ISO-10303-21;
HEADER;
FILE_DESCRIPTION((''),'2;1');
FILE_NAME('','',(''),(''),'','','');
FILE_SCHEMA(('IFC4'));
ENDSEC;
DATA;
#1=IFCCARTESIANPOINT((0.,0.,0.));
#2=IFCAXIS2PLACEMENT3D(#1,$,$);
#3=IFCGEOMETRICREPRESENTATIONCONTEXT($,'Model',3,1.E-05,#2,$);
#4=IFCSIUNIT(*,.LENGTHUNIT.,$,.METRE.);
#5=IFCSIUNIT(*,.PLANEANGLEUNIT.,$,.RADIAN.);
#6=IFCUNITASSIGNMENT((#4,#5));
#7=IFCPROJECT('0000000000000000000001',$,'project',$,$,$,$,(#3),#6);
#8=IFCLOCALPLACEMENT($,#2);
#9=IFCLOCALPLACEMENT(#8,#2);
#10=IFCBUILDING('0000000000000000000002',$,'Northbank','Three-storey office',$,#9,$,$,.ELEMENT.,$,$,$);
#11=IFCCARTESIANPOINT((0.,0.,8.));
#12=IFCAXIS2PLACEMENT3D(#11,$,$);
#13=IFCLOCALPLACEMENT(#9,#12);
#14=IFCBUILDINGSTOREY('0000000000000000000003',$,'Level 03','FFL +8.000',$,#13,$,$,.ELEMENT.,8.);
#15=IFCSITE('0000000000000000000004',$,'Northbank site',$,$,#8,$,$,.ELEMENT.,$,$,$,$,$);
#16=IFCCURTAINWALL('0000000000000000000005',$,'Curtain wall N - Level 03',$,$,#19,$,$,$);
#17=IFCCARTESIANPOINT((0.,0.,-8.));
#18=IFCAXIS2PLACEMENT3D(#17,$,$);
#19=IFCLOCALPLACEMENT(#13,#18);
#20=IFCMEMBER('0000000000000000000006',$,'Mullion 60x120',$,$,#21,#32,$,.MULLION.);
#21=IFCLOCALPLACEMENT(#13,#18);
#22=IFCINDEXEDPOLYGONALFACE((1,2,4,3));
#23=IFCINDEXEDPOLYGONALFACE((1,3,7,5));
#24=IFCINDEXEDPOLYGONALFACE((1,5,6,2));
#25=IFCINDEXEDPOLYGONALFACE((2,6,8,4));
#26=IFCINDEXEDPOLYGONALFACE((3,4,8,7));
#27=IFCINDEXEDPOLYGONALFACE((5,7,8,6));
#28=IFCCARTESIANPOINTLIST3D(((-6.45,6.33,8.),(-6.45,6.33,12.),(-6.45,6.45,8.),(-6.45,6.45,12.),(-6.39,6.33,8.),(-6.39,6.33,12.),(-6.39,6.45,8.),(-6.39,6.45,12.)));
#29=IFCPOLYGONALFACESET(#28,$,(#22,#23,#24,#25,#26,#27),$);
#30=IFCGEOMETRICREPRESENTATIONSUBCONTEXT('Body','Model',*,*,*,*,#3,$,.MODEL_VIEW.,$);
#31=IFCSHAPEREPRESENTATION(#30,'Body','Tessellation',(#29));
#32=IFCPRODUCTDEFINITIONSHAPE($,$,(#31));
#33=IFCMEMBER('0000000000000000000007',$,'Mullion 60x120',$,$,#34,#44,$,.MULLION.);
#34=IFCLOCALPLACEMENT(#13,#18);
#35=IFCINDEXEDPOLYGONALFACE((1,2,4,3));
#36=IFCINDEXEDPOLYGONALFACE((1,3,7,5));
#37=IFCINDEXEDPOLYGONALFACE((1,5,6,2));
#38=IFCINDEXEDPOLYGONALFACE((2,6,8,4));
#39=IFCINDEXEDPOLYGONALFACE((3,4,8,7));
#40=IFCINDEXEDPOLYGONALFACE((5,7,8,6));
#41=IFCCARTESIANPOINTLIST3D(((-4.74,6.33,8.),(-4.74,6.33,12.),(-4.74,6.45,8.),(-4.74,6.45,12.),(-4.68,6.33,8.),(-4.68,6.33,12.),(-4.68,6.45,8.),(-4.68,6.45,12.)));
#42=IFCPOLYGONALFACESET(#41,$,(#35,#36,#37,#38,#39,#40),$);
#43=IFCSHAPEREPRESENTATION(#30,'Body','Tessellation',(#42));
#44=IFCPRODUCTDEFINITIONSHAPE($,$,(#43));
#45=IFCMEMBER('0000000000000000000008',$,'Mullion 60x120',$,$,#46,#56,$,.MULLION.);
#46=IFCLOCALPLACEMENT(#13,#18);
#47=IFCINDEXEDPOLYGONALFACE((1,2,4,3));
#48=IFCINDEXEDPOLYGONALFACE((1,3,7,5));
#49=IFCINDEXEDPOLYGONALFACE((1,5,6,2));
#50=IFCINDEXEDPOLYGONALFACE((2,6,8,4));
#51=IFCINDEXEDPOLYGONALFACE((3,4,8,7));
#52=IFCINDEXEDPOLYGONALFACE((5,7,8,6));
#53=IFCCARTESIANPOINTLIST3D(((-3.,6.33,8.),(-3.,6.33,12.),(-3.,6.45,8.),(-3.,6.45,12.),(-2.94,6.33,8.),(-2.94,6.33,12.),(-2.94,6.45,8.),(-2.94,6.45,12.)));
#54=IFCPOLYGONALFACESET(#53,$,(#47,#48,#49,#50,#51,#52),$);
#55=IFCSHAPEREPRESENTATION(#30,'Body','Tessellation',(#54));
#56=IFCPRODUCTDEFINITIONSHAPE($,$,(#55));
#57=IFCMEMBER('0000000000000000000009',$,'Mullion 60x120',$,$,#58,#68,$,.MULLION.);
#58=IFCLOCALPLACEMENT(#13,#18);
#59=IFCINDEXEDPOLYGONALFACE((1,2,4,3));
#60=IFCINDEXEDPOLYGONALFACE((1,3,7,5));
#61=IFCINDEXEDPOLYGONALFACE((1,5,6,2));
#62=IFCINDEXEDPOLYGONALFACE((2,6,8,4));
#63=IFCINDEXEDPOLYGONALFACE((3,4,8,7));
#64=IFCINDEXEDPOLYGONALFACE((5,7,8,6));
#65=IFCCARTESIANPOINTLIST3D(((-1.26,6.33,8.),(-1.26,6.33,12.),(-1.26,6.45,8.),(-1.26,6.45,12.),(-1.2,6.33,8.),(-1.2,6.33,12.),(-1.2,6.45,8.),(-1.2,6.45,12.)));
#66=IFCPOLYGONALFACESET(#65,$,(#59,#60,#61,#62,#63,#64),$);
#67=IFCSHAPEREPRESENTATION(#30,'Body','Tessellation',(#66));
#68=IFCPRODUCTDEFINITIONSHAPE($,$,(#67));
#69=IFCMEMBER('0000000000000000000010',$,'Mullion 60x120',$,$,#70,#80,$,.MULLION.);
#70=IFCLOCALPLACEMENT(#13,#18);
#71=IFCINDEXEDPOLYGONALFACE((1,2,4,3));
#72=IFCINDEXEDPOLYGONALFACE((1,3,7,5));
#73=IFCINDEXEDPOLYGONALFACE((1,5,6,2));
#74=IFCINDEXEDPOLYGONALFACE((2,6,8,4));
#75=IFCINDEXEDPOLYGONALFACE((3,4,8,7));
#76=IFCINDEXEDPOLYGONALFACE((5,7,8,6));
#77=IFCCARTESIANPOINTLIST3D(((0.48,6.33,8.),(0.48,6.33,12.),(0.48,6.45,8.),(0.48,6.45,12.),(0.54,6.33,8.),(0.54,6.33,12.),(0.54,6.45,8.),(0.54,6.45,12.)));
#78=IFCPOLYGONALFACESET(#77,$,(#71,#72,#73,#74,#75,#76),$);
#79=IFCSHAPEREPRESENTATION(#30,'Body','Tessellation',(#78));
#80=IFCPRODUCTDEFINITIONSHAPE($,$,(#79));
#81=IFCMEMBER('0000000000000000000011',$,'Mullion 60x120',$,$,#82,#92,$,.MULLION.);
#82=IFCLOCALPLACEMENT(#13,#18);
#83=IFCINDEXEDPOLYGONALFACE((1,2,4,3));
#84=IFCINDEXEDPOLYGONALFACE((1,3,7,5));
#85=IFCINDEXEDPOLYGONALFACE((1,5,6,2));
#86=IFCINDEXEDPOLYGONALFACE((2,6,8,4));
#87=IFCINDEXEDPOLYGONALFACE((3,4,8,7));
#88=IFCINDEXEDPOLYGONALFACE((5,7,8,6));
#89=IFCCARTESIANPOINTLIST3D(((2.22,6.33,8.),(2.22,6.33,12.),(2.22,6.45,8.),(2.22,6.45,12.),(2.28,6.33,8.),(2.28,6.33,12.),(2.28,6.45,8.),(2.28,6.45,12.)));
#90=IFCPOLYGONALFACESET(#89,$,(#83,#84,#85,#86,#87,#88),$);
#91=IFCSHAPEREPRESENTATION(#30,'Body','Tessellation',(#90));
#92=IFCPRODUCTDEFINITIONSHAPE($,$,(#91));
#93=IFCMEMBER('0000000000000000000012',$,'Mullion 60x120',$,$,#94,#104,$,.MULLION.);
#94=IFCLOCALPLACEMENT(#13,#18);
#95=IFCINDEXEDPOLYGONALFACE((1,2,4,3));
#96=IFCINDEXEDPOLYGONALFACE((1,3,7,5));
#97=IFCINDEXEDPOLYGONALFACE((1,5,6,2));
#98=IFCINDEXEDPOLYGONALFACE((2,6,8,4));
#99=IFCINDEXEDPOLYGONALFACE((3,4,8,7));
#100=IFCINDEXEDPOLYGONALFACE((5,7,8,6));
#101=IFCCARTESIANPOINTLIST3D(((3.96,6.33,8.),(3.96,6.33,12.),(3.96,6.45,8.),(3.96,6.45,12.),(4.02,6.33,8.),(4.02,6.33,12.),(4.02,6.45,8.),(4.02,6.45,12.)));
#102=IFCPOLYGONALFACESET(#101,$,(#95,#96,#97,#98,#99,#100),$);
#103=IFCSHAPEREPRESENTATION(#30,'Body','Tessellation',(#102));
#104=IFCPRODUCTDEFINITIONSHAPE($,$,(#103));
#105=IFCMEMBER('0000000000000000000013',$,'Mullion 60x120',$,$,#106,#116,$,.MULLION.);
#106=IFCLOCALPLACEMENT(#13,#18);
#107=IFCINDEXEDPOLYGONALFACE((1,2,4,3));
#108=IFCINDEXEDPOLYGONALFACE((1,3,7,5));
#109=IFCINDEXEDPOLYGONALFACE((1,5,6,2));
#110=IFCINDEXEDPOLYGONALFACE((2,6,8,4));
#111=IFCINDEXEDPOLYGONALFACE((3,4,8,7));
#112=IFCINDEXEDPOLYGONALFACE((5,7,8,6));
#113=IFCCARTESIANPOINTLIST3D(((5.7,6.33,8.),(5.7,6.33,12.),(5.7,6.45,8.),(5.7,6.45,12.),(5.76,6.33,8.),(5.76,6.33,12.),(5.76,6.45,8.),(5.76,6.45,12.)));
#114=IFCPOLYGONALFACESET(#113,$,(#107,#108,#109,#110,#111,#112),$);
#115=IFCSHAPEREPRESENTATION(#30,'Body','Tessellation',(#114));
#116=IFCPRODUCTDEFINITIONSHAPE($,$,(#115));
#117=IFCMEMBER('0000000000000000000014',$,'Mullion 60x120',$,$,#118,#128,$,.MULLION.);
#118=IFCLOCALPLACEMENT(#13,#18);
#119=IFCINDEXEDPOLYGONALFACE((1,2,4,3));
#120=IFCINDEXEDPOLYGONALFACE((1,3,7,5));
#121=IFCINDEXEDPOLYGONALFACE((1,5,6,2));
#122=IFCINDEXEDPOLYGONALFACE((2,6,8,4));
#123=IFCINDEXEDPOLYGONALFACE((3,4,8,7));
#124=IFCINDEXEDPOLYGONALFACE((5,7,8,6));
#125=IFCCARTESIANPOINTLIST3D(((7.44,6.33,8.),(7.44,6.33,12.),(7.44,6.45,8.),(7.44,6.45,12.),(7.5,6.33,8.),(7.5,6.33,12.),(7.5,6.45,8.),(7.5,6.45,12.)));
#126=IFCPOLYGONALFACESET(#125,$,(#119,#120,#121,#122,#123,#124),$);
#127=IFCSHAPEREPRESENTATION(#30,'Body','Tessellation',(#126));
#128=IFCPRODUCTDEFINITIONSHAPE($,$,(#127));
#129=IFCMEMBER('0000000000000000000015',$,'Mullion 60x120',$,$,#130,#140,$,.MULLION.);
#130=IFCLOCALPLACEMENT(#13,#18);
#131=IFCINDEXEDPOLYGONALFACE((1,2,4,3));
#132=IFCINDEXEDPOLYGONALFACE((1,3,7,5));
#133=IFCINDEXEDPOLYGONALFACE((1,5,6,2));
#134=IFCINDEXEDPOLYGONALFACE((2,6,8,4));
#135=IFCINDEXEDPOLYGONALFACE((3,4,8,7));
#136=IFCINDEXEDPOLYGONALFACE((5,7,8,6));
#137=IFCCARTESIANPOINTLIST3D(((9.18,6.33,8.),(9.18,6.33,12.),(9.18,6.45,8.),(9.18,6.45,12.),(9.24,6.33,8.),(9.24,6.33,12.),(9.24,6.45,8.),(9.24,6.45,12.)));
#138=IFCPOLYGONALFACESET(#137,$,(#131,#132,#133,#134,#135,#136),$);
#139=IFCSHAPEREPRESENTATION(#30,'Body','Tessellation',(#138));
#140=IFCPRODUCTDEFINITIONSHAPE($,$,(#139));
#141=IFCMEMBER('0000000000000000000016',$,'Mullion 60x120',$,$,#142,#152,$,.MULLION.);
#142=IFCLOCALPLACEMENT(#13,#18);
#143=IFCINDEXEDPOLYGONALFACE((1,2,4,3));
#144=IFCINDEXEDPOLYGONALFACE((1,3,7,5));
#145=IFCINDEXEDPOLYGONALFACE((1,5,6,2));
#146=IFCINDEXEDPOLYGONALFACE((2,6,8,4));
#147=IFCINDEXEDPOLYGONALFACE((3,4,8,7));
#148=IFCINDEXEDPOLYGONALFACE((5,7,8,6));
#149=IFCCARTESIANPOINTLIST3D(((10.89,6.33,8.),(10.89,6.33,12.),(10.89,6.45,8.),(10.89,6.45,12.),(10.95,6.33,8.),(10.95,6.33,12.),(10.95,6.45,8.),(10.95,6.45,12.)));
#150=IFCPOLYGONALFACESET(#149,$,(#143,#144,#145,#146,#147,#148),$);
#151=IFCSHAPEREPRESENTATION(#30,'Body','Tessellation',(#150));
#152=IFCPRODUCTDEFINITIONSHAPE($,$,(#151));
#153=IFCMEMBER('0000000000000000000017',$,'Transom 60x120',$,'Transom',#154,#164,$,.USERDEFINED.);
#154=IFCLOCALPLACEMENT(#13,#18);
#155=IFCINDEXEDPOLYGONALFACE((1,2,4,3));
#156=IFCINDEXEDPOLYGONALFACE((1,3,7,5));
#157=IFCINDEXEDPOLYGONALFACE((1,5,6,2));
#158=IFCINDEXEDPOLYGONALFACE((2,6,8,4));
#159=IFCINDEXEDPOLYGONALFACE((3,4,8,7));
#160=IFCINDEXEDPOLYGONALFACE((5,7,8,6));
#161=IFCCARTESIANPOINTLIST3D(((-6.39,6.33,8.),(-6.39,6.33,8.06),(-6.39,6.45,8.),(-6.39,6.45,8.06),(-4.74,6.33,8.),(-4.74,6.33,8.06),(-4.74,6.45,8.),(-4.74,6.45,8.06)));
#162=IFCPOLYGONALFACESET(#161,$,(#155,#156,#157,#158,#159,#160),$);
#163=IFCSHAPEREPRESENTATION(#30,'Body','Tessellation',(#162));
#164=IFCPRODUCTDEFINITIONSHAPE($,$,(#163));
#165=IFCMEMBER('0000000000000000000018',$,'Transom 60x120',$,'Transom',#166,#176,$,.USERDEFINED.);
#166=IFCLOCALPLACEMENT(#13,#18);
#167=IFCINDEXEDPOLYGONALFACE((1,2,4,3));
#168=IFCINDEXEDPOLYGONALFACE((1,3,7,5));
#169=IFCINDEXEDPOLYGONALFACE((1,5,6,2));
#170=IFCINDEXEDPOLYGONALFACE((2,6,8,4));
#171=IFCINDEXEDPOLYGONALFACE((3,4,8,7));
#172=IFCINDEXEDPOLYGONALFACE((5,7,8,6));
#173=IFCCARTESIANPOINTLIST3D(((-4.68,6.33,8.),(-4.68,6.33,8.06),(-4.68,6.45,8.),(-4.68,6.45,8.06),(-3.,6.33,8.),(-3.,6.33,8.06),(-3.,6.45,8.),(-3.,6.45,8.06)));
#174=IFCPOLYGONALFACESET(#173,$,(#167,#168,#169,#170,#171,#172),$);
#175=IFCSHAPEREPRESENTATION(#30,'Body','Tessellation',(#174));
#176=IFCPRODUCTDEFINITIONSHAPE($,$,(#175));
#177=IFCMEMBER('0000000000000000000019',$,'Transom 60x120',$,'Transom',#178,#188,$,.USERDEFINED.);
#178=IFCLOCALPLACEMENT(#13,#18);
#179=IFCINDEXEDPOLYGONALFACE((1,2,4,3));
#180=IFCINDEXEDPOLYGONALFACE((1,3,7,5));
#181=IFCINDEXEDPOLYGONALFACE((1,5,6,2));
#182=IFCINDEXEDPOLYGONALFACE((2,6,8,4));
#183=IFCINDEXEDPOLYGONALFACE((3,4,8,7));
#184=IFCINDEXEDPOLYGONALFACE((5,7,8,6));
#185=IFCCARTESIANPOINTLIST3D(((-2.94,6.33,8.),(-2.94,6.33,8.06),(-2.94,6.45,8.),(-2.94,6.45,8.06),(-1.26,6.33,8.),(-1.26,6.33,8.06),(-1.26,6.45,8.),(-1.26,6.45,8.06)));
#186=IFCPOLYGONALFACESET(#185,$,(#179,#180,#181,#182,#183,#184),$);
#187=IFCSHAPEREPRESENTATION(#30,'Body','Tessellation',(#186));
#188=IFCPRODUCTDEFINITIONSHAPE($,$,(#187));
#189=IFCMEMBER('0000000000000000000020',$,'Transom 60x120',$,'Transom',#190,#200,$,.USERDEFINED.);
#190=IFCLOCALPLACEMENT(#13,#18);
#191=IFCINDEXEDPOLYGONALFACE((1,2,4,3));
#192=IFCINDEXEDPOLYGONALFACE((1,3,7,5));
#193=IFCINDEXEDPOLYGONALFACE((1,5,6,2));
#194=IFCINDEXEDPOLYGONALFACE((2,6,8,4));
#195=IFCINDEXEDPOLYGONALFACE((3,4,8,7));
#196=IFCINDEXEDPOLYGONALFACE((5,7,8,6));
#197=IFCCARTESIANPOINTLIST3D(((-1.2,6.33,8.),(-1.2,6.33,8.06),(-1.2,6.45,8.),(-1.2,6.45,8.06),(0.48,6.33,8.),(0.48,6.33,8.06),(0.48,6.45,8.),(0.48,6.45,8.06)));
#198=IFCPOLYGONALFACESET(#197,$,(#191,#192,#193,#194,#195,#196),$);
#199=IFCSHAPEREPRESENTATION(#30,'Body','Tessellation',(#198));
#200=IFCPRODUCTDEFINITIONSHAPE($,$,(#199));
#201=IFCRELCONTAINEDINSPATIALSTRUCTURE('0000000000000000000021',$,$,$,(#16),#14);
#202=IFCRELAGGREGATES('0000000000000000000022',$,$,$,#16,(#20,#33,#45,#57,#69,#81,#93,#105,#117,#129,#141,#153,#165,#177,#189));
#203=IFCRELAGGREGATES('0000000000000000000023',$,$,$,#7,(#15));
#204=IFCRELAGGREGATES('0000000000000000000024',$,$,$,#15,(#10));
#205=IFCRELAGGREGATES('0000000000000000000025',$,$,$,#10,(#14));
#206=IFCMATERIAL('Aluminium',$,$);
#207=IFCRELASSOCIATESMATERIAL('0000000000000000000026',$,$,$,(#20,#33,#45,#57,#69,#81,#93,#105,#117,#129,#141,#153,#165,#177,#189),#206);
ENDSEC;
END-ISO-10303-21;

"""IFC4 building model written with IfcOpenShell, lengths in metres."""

from ifc_helpers import new_model, si_unit, frame, origin, place, context, subcontext, project, spatial, rectangle, extrude, material, element, aggregate, save


model = new_model("IFC4")

# Units and contexts
model_context = context("Model", 3, precision=1e-05, world=origin())
body_context = subcontext(model_context, "Body", "Model", "MODEL_VIEW")
ifc_project = project(units=[si_unit("LENGTHUNIT", "METRE"), si_unit("PLANEANGLEUNIT", "RADIAN")], contexts=[model_context])

# Site, building, storey
site_placement = place(None, origin())
site = spatial("IfcSite", under=ifc_project, at=site_placement, Name="Northbank site", CompositionType="ELEMENT")
building_placement = place(site_placement, origin())
building = spatial("IfcBuilding", under=site, at=building_placement, Name="Northbank", Description="Three-storey office", CompositionType="ELEMENT")
storey_placement = place(building_placement, frame((0.0, 0.0, 8.0)))
storey = spatial("IfcBuildingStorey", under=building, at=storey_placement, Name="Level 03", Description="FFL +8.000", CompositionType="ELEMENT", Elevation=8.0)

# Curtain wall, members
curtain_wall_1_placement = place(storey_placement, frame((0.0, 0.0, -8.0)))
curtain_wall_1 = element("IfcCurtainWall", 1, at=curtain_wall_1_placement, inside=storey, Name="Curtain wall N - Level 03")
ifc_material_1 = material(Name="Aluminium")
member_1_placement = place(storey_placement, frame((0.0, 0.0, -8.0)))
member_1 = element("IfcMember", 2, at=member_1_placement, material=ifc_material_1, Name="Mullion 60x120", PredefinedType="MULLION", context=body_context, shape_type="SweptSolid", body=[
    extrude(rectangle(XDim=0.06, YDim=0.12), frame((-6.42, 6.39, 8.0)), (0.0, 0.0, 1.0), 4.0),
])
member_2_placement = place(storey_placement, frame((0.0, 0.0, -8.0)))
member_2 = element("IfcMember", 3, at=member_2_placement, material=ifc_material_1, Name="Mullion 60x120", PredefinedType="MULLION", context=body_context, shape_type="SweptSolid", body=[
    extrude(rectangle(XDim=0.06, YDim=0.12), frame((-4.71, 6.39, 8.0)), (0.0, 0.0, 1.0), 4.0),
])
member_3_placement = place(storey_placement, frame((0.0, 0.0, -8.0)))
member_3 = element("IfcMember", 4, at=member_3_placement, material=ifc_material_1, Name="Mullion 60x120", PredefinedType="MULLION", context=body_context, shape_type="SweptSolid", body=[
    extrude(rectangle(XDim=0.06, YDim=0.12), frame((-2.97, 6.39, 8.0)), (0.0, 0.0, 1.0), 4.0),
])
member_4_placement = place(storey_placement, frame((0.0, 0.0, -8.0)))
member_4 = element("IfcMember", 5, at=member_4_placement, material=ifc_material_1, Name="Mullion 60x120", PredefinedType="MULLION", context=body_context, shape_type="SweptSolid", body=[
    extrude(rectangle(XDim=0.06, YDim=0.12), frame((-1.23, 6.39, 8.0)), (0.0, 0.0, 1.0), 4.0),
])
member_5_placement = place(storey_placement, frame((0.0, 0.0, -8.0)))
member_5 = element("IfcMember", 6, at=member_5_placement, material=ifc_material_1, Name="Mullion 60x120", PredefinedType="MULLION", context=body_context, shape_type="SweptSolid", body=[
    extrude(rectangle(XDim=0.06, YDim=0.12), frame((0.51, 6.39, 8.0)), (0.0, 0.0, 1.0), 4.0),
])
member_6_placement = place(storey_placement, frame((0.0, 0.0, -8.0)))
member_6 = element("IfcMember", 7, at=member_6_placement, material=ifc_material_1, Name="Mullion 60x120", PredefinedType="MULLION", context=body_context, shape_type="SweptSolid", body=[
    extrude(rectangle(XDim=0.06, YDim=0.12), frame((2.25, 6.39, 8.0)), (0.0, 0.0, 1.0), 4.0),
])
member_7_placement = place(storey_placement, frame((0.0, 0.0, -8.0)))
member_7 = element("IfcMember", 8, at=member_7_placement, material=ifc_material_1, Name="Mullion 60x120", PredefinedType="MULLION", context=body_context, shape_type="SweptSolid", body=[
    extrude(rectangle(XDim=0.06, YDim=0.12), frame((3.99, 6.39, 8.0)), (0.0, 0.0, 1.0), 4.0),
])
member_8_placement = place(storey_placement, frame((0.0, 0.0, -8.0)))
member_8 = element("IfcMember", 9, at=member_8_placement, material=ifc_material_1, Name="Mullion 60x120", PredefinedType="MULLION", context=body_context, shape_type="SweptSolid", body=[
    extrude(rectangle(XDim=0.06, YDim=0.12), frame((5.73, 6.39, 8.0)), (0.0, 0.0, 1.0), 4.0),
])
member_9_placement = place(storey_placement, frame((0.0, 0.0, -8.0)))
member_9 = element("IfcMember", 10, at=member_9_placement, material=ifc_material_1, Name="Mullion 60x120", PredefinedType="MULLION", context=body_context, shape_type="SweptSolid", body=[
    extrude(rectangle(XDim=0.06, YDim=0.12), frame((7.47, 6.39, 8.0)), (0.0, 0.0, 1.0), 4.0),
])
member_10_placement = place(storey_placement, frame((0.0, 0.0, -8.0)))
member_10 = element("IfcMember", 11, at=member_10_placement, material=ifc_material_1, Name="Mullion 60x120", PredefinedType="MULLION", context=body_context, shape_type="SweptSolid", body=[
    extrude(rectangle(XDim=0.06, YDim=0.12), frame((9.21, 6.39, 8.0)), (0.0, 0.0, 1.0), 4.0),
])
member_11_placement = place(storey_placement, frame((0.0, 0.0, -8.0)))
member_11 = element("IfcMember", 12, at=member_11_placement, material=ifc_material_1, Name="Mullion 60x120", PredefinedType="MULLION", context=body_context, shape_type="SweptSolid", body=[
    extrude(rectangle(XDim=0.06, YDim=0.12), frame((10.92, 6.39, 8.0)), (0.0, 0.0, 1.0), 4.0),
])
member_12_placement = place(storey_placement, frame((0.0, 0.0, -8.0)))
member_12 = element("IfcMember", 13, at=member_12_placement, material=ifc_material_1, Name="Transom 60x120", ObjectType="Transom", PredefinedType="USERDEFINED", context=body_context, shape_type="SweptSolid", body=[
    extrude(rectangle(XDim=1.65, YDim=0.12), frame((-5.565, 6.39, 8.0)), (0.0, 0.0, 1.0), 0.06),
])
member_13_placement = place(storey_placement, frame((0.0, 0.0, -8.0)))
member_13 = element("IfcMember", 14, at=member_13_placement, material=ifc_material_1, Name="Transom 60x120", ObjectType="Transom", PredefinedType="USERDEFINED", context=body_context, shape_type="SweptSolid", body=[
    extrude(rectangle(XDim=1.68, YDim=0.12), frame((-3.84, 6.39, 8.0)), (0.0, 0.0, 1.0), 0.06),
])
member_14_placement = place(storey_placement, frame((0.0, 0.0, -8.0)))
member_14 = element("IfcMember", 15, at=member_14_placement, material=ifc_material_1, Name="Transom 60x120", ObjectType="Transom", PredefinedType="USERDEFINED", context=body_context, shape_type="SweptSolid", body=[
    extrude(rectangle(XDim=1.68, YDim=0.12), frame((-2.1, 6.39, 8.0)), (0.0, 0.0, 1.0), 0.06),
])
member_15_placement = place(storey_placement, frame((0.0, 0.0, -8.0)))
member_15 = element("IfcMember", 16, at=member_15_placement, material=ifc_material_1, Name="Transom 60x120", ObjectType="Transom", PredefinedType="USERDEFINED", context=body_context, shape_type="SweptSolid", body=[
    extrude(rectangle(XDim=1.68, YDim=0.12), frame((-0.36, 6.39, 8.0)), (0.0, 0.0, 1.0), 0.06),
])
aggregate(curtain_wall_1, [member_1, member_2, member_3, member_4, member_5, member_6, member_7, member_8, member_9, member_10, member_11, member_12, member_13, member_14, member_15])

save(model, "model.ifc")
